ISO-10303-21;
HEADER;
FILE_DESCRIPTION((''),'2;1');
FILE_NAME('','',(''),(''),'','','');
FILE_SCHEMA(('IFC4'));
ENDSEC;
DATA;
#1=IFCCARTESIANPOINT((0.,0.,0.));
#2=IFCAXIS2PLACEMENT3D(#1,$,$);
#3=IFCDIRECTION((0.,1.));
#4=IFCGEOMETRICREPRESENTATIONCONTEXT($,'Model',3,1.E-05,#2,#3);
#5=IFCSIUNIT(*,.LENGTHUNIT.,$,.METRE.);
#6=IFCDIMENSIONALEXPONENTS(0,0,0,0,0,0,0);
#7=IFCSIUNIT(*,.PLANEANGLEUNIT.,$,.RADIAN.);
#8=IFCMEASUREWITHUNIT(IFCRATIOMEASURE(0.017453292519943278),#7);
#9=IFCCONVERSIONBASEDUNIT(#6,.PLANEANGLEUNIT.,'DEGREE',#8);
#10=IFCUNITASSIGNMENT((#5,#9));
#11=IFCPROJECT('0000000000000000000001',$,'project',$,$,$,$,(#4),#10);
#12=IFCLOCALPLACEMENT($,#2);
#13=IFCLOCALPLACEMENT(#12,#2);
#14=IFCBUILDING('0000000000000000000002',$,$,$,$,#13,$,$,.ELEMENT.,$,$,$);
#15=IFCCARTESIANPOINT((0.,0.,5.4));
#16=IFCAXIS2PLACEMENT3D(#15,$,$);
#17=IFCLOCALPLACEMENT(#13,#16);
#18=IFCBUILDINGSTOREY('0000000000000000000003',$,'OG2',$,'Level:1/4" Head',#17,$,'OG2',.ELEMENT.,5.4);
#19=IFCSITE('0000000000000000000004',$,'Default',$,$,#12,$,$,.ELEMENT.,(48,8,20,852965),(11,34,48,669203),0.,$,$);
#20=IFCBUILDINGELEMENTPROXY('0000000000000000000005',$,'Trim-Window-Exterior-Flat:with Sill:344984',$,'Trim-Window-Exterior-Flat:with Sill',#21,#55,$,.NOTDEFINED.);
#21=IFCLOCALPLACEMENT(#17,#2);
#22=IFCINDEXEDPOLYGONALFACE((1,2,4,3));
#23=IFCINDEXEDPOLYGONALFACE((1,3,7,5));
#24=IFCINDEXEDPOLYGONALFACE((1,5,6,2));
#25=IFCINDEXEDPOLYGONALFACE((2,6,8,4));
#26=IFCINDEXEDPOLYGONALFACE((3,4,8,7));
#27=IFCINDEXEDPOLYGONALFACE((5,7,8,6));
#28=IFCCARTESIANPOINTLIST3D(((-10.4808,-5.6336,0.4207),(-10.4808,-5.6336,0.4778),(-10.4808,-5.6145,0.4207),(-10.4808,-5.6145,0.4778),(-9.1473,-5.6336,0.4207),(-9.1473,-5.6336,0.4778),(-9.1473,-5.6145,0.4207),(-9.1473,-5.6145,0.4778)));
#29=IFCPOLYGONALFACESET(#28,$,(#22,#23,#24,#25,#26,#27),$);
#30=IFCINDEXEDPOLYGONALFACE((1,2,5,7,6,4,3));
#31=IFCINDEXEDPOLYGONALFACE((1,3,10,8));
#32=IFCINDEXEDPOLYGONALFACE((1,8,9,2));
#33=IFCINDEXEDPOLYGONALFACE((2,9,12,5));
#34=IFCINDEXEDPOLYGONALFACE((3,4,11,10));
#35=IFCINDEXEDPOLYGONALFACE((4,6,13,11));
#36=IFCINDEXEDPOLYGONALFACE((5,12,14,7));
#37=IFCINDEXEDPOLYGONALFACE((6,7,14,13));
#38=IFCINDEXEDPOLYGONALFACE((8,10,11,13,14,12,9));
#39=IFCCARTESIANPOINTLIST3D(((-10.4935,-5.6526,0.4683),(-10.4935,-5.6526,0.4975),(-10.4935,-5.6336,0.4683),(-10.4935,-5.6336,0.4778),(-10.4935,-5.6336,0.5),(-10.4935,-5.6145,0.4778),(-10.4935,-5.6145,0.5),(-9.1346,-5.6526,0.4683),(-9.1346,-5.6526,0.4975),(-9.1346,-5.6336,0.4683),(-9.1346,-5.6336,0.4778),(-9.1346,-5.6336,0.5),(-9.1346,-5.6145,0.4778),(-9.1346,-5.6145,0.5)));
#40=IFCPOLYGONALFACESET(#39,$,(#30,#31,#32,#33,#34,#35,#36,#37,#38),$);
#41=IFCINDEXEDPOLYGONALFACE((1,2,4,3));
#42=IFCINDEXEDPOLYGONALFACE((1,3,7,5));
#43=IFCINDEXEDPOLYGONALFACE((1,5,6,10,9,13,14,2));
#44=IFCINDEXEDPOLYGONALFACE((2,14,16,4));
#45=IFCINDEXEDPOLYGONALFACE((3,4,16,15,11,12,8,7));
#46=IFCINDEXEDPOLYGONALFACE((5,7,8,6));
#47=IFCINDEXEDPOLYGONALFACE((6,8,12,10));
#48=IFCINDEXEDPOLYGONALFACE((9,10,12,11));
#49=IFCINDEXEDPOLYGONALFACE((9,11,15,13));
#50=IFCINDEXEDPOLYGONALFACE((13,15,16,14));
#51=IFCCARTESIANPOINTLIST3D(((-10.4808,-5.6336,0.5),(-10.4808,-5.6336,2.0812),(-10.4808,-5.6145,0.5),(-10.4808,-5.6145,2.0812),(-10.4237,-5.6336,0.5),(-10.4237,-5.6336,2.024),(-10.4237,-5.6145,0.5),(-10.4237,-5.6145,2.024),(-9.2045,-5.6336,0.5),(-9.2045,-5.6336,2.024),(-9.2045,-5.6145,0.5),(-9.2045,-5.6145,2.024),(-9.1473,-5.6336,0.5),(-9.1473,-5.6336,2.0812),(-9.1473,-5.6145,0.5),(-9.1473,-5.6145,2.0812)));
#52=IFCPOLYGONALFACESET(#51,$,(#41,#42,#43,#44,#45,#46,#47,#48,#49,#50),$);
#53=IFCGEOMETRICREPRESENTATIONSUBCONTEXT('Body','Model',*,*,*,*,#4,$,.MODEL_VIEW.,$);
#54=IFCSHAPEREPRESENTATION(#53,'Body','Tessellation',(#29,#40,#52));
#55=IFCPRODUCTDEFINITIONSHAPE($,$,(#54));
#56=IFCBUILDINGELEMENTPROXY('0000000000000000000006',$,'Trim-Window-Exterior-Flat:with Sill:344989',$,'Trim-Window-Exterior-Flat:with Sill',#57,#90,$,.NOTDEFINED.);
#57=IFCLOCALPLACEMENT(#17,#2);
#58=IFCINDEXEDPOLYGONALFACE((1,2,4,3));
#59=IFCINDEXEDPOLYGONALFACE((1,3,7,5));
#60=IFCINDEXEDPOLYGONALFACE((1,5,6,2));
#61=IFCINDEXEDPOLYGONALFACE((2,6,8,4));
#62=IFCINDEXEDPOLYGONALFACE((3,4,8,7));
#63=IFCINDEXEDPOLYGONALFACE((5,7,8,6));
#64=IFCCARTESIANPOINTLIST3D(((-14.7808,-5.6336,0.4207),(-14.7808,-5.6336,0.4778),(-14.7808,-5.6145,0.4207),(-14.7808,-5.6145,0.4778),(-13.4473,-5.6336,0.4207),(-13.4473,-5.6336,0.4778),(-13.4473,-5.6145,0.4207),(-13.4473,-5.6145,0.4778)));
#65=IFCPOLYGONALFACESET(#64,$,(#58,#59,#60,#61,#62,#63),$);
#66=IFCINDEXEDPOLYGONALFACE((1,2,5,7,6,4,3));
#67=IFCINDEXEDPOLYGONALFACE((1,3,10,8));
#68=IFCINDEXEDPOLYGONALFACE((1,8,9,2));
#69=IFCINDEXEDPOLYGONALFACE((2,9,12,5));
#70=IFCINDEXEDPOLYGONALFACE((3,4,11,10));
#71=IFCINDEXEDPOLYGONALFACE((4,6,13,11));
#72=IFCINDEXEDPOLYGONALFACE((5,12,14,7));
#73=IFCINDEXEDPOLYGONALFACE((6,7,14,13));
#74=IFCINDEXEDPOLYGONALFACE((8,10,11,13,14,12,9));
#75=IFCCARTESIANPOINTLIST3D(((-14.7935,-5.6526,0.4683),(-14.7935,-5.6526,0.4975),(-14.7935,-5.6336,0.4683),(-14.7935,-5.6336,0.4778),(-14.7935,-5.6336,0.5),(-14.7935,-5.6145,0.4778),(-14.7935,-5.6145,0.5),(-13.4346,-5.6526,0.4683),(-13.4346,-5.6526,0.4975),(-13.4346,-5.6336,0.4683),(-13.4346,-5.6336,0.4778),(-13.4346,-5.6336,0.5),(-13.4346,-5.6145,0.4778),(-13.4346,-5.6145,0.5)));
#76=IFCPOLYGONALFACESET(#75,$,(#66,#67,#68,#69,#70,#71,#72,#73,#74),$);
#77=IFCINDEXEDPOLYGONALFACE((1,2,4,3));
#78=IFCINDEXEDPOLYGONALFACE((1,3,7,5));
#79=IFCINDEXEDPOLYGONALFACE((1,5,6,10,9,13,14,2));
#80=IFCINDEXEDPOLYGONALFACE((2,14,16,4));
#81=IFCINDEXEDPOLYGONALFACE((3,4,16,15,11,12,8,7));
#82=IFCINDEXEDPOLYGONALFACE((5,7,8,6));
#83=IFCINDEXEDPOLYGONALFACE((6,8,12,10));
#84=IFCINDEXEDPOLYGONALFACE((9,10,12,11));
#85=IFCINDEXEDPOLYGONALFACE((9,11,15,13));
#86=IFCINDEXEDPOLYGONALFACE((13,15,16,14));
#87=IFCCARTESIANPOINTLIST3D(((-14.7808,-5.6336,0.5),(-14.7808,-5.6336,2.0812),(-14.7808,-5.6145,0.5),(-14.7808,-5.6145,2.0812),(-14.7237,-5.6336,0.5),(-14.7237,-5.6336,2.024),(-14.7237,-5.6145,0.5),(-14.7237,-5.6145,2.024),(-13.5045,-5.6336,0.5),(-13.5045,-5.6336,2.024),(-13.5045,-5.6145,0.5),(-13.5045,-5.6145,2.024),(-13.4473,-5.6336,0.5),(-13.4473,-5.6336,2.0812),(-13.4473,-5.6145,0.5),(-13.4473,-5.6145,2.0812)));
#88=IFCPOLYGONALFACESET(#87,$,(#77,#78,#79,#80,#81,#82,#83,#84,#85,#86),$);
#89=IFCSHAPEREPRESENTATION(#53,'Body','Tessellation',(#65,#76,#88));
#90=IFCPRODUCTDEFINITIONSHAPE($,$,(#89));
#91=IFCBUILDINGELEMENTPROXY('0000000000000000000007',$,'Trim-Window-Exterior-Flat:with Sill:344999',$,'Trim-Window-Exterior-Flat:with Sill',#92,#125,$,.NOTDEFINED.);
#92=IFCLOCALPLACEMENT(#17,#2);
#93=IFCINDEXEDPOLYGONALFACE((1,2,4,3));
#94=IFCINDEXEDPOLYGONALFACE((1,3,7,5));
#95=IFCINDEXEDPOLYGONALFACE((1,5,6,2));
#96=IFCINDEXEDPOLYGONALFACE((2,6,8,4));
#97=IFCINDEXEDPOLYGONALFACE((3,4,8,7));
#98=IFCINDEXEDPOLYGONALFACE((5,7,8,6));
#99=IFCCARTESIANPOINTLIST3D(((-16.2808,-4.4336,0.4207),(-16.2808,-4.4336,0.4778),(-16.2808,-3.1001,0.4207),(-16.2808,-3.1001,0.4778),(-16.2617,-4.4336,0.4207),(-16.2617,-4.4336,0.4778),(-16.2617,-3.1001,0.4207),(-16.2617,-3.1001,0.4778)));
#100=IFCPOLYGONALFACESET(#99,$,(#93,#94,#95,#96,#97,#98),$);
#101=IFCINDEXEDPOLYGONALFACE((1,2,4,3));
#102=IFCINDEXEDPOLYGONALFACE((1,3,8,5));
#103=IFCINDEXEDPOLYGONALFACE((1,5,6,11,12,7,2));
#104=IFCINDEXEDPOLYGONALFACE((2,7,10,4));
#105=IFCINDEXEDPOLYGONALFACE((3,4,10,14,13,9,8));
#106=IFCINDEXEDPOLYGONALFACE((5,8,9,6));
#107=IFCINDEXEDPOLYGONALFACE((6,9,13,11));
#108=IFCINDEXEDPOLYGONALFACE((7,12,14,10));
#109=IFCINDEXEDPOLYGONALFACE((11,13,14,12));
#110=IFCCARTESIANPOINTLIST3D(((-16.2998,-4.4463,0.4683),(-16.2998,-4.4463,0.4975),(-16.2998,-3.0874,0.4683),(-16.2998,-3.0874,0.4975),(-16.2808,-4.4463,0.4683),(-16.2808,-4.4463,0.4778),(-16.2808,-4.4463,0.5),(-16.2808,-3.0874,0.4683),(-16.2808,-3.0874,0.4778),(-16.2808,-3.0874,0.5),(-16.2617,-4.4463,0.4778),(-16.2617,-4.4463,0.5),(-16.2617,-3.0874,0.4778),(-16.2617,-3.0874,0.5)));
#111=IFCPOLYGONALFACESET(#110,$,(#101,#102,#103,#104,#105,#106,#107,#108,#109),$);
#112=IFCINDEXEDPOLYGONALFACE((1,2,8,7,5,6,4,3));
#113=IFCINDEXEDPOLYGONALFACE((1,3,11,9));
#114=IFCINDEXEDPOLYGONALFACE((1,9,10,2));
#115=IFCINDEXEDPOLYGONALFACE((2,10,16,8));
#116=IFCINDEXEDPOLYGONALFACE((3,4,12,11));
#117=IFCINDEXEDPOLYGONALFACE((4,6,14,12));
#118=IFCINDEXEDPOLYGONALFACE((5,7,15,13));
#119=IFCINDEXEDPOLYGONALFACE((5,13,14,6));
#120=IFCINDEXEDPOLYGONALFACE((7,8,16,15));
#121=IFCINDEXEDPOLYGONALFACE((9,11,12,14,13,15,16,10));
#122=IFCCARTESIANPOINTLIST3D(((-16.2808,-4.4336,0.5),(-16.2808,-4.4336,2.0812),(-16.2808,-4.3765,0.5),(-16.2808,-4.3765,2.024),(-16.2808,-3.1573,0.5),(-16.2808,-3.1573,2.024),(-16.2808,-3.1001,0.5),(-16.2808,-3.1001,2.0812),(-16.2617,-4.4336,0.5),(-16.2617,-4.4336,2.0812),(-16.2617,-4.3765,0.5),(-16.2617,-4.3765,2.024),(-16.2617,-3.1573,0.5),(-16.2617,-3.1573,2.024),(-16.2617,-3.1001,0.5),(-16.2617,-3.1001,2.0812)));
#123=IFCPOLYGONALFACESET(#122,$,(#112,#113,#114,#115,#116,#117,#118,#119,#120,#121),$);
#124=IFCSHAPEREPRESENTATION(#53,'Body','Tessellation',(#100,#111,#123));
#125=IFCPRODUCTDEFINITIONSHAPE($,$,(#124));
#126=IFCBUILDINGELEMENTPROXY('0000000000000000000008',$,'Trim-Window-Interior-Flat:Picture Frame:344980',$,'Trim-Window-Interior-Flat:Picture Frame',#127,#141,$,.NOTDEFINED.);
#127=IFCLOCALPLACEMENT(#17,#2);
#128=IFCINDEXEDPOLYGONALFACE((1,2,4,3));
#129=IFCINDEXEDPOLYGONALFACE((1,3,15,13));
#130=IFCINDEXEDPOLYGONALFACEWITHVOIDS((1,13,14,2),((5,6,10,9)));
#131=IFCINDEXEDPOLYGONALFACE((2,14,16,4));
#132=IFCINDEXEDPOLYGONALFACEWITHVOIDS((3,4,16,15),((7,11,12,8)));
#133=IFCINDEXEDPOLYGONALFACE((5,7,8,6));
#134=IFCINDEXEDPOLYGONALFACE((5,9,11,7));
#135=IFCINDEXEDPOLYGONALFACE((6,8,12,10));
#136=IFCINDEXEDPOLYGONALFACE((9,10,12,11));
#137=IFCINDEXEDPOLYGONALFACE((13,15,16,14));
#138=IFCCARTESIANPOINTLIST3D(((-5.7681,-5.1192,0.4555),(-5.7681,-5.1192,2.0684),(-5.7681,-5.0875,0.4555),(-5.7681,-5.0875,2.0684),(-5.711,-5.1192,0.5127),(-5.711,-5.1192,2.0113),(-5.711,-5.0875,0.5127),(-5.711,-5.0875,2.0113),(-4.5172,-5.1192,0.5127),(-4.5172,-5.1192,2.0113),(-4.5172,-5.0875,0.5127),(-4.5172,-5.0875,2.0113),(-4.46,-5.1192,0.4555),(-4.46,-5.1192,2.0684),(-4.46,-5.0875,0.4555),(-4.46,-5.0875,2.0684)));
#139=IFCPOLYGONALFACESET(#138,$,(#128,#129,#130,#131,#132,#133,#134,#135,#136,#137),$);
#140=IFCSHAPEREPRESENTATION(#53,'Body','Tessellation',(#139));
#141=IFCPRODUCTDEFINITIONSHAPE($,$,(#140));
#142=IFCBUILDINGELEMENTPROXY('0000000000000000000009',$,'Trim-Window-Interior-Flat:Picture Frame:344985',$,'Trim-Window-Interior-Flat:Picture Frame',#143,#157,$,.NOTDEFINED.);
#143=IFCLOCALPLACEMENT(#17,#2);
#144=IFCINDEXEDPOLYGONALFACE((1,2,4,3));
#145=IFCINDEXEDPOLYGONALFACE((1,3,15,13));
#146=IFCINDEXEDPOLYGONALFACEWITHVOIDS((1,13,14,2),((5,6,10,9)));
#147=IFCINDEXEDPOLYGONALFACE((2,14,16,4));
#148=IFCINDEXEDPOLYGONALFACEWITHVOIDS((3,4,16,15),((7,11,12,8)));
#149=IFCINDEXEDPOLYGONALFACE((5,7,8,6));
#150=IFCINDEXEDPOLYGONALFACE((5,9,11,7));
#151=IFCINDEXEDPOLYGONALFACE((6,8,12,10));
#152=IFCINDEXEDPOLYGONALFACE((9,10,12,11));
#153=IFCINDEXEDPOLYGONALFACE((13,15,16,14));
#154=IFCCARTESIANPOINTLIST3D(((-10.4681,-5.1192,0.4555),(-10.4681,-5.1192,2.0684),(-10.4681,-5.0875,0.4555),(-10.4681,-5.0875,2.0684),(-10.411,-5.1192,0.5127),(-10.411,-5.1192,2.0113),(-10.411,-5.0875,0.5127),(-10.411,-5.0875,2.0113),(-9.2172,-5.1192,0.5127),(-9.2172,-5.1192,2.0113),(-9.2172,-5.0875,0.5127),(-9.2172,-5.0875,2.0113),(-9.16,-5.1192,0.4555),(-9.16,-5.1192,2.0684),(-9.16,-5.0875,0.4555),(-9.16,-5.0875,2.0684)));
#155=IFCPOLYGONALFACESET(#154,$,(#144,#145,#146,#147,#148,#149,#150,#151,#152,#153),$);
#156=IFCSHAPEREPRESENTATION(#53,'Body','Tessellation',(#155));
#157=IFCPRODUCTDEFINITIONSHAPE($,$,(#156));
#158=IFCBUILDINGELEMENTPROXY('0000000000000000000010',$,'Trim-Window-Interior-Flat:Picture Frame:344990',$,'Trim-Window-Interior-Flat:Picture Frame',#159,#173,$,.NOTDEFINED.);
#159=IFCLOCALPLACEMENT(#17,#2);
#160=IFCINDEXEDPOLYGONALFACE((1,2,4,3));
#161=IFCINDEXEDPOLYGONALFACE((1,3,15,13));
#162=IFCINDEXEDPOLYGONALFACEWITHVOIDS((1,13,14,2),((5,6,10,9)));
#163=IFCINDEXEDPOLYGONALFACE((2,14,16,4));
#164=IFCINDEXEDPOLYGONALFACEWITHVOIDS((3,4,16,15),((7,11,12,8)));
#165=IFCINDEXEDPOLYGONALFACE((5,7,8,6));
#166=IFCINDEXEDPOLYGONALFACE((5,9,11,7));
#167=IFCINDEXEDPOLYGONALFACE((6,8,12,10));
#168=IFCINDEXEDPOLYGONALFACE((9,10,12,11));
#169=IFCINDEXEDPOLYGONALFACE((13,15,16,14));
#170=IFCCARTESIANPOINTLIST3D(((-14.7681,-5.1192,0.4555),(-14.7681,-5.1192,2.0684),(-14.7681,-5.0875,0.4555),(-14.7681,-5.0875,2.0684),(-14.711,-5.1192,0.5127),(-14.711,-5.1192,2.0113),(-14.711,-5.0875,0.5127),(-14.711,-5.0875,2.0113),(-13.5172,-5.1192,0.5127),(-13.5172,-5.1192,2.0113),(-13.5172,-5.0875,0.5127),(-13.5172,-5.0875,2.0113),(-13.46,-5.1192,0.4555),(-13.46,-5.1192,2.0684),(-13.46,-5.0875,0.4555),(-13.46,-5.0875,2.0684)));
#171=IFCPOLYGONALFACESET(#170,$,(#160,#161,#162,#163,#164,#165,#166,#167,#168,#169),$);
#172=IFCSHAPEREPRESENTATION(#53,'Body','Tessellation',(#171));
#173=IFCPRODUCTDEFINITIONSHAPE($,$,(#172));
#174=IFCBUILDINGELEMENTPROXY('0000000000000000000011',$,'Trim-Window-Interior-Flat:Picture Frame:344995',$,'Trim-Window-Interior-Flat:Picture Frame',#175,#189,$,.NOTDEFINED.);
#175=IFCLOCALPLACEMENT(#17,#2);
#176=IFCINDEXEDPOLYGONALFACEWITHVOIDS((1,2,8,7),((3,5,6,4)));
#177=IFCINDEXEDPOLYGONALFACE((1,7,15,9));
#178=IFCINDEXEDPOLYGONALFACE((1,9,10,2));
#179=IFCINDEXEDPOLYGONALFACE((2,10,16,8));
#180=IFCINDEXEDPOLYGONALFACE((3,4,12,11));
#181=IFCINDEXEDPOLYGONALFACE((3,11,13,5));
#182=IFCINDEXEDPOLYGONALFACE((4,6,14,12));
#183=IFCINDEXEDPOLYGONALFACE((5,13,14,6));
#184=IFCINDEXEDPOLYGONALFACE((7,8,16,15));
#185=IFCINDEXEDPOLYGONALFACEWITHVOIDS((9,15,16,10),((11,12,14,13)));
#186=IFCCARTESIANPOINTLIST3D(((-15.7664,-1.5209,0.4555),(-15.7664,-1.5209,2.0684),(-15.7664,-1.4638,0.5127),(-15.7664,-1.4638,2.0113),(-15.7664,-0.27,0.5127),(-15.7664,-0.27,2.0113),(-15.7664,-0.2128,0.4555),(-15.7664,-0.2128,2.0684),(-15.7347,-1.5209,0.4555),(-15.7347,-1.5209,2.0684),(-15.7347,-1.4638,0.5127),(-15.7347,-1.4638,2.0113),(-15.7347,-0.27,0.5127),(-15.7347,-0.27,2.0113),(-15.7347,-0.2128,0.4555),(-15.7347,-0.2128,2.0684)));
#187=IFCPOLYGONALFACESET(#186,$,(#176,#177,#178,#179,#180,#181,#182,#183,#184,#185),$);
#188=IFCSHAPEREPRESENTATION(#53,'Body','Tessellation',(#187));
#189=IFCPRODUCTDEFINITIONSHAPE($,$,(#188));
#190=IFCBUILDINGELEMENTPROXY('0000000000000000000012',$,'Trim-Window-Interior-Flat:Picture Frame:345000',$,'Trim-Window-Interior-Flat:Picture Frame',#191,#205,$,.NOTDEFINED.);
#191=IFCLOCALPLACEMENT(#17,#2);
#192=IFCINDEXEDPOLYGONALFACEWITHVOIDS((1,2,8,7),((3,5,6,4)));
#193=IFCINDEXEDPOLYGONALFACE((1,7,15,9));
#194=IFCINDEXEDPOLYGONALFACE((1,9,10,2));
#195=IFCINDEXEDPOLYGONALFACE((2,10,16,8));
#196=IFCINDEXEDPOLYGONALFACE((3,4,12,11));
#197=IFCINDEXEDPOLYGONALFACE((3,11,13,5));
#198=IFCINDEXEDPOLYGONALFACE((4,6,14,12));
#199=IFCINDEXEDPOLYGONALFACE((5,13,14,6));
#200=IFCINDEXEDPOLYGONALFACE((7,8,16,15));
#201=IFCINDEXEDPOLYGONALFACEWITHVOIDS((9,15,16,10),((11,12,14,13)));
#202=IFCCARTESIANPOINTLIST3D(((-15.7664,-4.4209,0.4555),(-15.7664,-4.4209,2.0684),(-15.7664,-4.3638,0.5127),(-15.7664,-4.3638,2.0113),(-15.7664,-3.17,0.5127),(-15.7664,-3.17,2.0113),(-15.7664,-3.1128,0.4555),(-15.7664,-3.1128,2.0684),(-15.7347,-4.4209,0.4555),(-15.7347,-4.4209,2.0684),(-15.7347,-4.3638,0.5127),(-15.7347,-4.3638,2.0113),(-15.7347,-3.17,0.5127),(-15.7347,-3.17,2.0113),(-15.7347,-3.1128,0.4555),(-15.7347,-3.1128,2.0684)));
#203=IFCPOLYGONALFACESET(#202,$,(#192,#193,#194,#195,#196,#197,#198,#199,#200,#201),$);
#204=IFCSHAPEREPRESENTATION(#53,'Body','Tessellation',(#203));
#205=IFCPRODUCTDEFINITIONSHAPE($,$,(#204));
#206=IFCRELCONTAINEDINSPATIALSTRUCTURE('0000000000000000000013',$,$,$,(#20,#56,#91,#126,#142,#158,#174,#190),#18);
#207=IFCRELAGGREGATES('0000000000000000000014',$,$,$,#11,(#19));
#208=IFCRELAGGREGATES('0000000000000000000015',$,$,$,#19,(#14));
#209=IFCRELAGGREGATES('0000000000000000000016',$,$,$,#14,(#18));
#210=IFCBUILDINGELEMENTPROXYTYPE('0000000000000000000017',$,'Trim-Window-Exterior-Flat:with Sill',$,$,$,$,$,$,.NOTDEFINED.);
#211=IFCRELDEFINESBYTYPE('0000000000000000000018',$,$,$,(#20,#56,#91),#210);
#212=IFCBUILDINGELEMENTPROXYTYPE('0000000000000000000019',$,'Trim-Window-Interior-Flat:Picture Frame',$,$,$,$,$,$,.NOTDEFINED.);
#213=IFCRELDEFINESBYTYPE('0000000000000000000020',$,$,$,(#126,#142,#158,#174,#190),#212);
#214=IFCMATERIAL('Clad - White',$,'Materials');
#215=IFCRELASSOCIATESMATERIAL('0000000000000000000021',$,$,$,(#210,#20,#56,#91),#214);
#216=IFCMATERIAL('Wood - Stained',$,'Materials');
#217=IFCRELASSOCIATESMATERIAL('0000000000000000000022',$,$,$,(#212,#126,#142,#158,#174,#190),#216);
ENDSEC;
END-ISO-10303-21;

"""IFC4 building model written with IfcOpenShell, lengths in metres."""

from ifc_helpers import new_model, entity, si_unit, converted_unit, direction, frame, origin, place, context, subcontext, project, spatial, indexed_curve, outline, extrude, source, transform, mapped, material, type_object, type_shapes, element, save


model = new_model("IFC4")

# Units and contexts
model_context = context("Model", 3, precision=1e-05, world=origin(), true_north=direction((0.0, 1.0)))
body_context = subcontext(model_context, "Body", "Model", "MODEL_VIEW")
ifc_project = project(units=[si_unit("LENGTHUNIT", "METRE"), converted_unit("PLANEANGLEUNIT", "DEGREE", entity("IfcRatioMeasure", 0.017453292519943278), si_unit("PLANEANGLEUNIT", "RADIAN"), dimensions=[0, 0, 0, 0, 0, 0, 0])], contexts=[model_context])

# Site, building, storey
site_placement = place(None, origin())
site = spatial("IfcSite", under=ifc_project, at=site_placement, Name="Default", CompositionType="ELEMENT", RefLatitude=(48, 8, 20, 852965), RefLongitude=(11, 34, 48, 669203), RefElevation=0.0)
building_placement = place(site_placement, origin())
building = spatial("IfcBuilding", under=site, at=building_placement, CompositionType="ELEMENT")
storey_placement = place(building_placement, frame((0.0, 0.0, 5.4)))
storey = spatial("IfcBuildingStorey", under=building, at=storey_placement, Name="OG2", ObjectType="Level:1/4\" Head", LongName="OG2", CompositionType="ELEMENT", Elevation=5.4)

# Building element proxies
ifc_material_1 = material(Name="Clad - White", Category="Materials")
ifc_material_2 = material(Name="Wood - Stained", Category="Materials")
building_element_proxy_type_1 = type_object("IfcBuildingElementProxyType", Name="Trim-Window-Exterior-Flat:with Sill", PredefinedType="NOTDEFINED", material=ifc_material_1)
shared_shape_1 = source(origin(), body_context, "Body", "SweptSolid", [
    extrude(outline(indexed_curve([(-0.6667, -0.0286), (0.6667, -0.0286), (0.6667, 0.0286), (-0.6667, 0.0286), (-0.6667, -0.0286)], self_intersect=False)), frame((0.0, -1.5748, 0.0), z_axis=(0.0, 0.0, 1.0), x_axis=(-1.0, 0.0, 0.0)), (0.0, 0.0, 1.0), 0.019),
    extrude(outline(indexed_curve([(-0.019, -0.016), (0.0, -0.016), (0.0, -0.0064), (0.019, -0.0064), (0.019, 0.0158), (0.0, 0.0158), (-0.019, 0.0133), (-0.019, -0.016)], self_intersect=False)), frame((-0.6794, -1.5398, 0.019), z_axis=(1.0, 0.0, 0.0), x_axis=(0.0, 0.0, -1.0)), (0.0, 0.0, 1.0), 1.3589),
    extrude(outline(indexed_curve([(-0.8049, -0.6667), (0.7763, -0.6667), (0.7763, -0.6096), (-0.7477, -0.6096), (-0.7477, 0.6096), (0.7763, 0.6096), (0.7763, 0.6667), (-0.8049, 0.6667), (-0.8049, -0.6667)], self_intersect=False)), frame((0.0, -0.7477, 0.0), z_axis=(0.0, 0.0, 1.0), x_axis=(0.0, -1.0, 0.0)), (0.0, 0.0, 1.0), 0.019),
])
type_shapes(building_element_proxy_type_1, [shared_shape_1])
for number, where, z_axis, x_axis, name in (
    (1, (-9.8141, -5.6145, 2.024), (0.0, -1.0, 0.0), (1.0, 0.0, 0.0), "Trim-Window-Exterior-Flat:with Sill:344984"),
    (2, (-14.1141, -5.6145, 2.024), (0.0, -1.0, 0.0), (1.0, 0.0, 0.0), "Trim-Window-Exterior-Flat:with Sill:344989"),
    (3, (-16.2617, -3.7669, 2.024), (-1.0, 0.0, 0.0), (0.0, -1.0, 0.0), "Trim-Window-Exterior-Flat:with Sill:344999"),
):
    element("IfcBuildingElementProxy", number, at=place(storey_placement, frame(where, z_axis=z_axis, x_axis=x_axis)), inside=storey, type_object=building_element_proxy_type_1, material=ifc_material_1, Name=name, ObjectType="Trim-Window-Exterior-Flat:with Sill", PredefinedType="NOTDEFINED", context=body_context, shape_type="MappedRepresentation", body=[
        mapped(shared_shape_1, transform((0.0, 0.0, 0.0), scale=1.0)),
    ])
building_element_proxy_type_2 = type_object("IfcBuildingElementProxyType", Name="Trim-Window-Interior-Flat:Picture Frame", PredefinedType="NOTDEFINED", material=ifc_material_2)
shared_shape_2 = source(origin(), body_context, "Body", "SweptSolid", [
    extrude(outline(indexed_curve([(-0.654, -0.8064), (0.654, -0.8064), (0.654, 0.8064), (-0.654, 0.8064), (-0.654, -0.8064)], self_intersect=False), holes=[indexed_curve([(-0.5969, -0.7493), (-0.5969, 0.7493), (0.5969, 0.7493), (0.5969, -0.7493), (-0.5969, -0.7493)], self_intersect=False)]), frame((0.0, -0.762, 0.0), z_axis=(0.0, 0.0, 1.0), x_axis=(-1.0, 0.0, 0.0)), (0.0, 0.0, 1.0), 0.0317),
])
type_shapes(building_element_proxy_type_2, [shared_shape_2])
for number, where, z_axis, x_axis, name in (
    (4, (-5.1141, -5.1192, 2.024), (0.0, 1.0, 0.0), (-1.0, 0.0, 0.0), "Trim-Window-Interior-Flat:Picture Frame:344980"),
    (5, (-9.8141, -5.1192, 2.024), (0.0, 1.0, 0.0), (-1.0, 0.0, 0.0), "Trim-Window-Interior-Flat:Picture Frame:344985"),
    (6, (-14.1141, -5.1192, 2.024), (0.0, 1.0, 0.0), (-1.0, 0.0, 0.0), "Trim-Window-Interior-Flat:Picture Frame:344990"),
    (7, (-15.7664, -0.8669, 2.024), (1.0, 0.0, 0.0), (0.0, 1.0, 0.0), "Trim-Window-Interior-Flat:Picture Frame:344995"),
    (8, (-15.7664, -3.7669, 2.024), (1.0, 0.0, 0.0), (0.0, 1.0, 0.0), "Trim-Window-Interior-Flat:Picture Frame:345000"),
):
    element("IfcBuildingElementProxy", number, at=place(storey_placement, frame(where, z_axis=z_axis, x_axis=x_axis)), inside=storey, type_object=building_element_proxy_type_2, material=ifc_material_2, Name=name, ObjectType="Trim-Window-Interior-Flat:Picture Frame", PredefinedType="NOTDEFINED", context=body_context, shape_type="MappedRepresentation", body=[
        mapped(shared_shape_2, transform((0.0, 0.0, 0.0), scale=1.0)),
    ])

save(model, "model.ifc")
